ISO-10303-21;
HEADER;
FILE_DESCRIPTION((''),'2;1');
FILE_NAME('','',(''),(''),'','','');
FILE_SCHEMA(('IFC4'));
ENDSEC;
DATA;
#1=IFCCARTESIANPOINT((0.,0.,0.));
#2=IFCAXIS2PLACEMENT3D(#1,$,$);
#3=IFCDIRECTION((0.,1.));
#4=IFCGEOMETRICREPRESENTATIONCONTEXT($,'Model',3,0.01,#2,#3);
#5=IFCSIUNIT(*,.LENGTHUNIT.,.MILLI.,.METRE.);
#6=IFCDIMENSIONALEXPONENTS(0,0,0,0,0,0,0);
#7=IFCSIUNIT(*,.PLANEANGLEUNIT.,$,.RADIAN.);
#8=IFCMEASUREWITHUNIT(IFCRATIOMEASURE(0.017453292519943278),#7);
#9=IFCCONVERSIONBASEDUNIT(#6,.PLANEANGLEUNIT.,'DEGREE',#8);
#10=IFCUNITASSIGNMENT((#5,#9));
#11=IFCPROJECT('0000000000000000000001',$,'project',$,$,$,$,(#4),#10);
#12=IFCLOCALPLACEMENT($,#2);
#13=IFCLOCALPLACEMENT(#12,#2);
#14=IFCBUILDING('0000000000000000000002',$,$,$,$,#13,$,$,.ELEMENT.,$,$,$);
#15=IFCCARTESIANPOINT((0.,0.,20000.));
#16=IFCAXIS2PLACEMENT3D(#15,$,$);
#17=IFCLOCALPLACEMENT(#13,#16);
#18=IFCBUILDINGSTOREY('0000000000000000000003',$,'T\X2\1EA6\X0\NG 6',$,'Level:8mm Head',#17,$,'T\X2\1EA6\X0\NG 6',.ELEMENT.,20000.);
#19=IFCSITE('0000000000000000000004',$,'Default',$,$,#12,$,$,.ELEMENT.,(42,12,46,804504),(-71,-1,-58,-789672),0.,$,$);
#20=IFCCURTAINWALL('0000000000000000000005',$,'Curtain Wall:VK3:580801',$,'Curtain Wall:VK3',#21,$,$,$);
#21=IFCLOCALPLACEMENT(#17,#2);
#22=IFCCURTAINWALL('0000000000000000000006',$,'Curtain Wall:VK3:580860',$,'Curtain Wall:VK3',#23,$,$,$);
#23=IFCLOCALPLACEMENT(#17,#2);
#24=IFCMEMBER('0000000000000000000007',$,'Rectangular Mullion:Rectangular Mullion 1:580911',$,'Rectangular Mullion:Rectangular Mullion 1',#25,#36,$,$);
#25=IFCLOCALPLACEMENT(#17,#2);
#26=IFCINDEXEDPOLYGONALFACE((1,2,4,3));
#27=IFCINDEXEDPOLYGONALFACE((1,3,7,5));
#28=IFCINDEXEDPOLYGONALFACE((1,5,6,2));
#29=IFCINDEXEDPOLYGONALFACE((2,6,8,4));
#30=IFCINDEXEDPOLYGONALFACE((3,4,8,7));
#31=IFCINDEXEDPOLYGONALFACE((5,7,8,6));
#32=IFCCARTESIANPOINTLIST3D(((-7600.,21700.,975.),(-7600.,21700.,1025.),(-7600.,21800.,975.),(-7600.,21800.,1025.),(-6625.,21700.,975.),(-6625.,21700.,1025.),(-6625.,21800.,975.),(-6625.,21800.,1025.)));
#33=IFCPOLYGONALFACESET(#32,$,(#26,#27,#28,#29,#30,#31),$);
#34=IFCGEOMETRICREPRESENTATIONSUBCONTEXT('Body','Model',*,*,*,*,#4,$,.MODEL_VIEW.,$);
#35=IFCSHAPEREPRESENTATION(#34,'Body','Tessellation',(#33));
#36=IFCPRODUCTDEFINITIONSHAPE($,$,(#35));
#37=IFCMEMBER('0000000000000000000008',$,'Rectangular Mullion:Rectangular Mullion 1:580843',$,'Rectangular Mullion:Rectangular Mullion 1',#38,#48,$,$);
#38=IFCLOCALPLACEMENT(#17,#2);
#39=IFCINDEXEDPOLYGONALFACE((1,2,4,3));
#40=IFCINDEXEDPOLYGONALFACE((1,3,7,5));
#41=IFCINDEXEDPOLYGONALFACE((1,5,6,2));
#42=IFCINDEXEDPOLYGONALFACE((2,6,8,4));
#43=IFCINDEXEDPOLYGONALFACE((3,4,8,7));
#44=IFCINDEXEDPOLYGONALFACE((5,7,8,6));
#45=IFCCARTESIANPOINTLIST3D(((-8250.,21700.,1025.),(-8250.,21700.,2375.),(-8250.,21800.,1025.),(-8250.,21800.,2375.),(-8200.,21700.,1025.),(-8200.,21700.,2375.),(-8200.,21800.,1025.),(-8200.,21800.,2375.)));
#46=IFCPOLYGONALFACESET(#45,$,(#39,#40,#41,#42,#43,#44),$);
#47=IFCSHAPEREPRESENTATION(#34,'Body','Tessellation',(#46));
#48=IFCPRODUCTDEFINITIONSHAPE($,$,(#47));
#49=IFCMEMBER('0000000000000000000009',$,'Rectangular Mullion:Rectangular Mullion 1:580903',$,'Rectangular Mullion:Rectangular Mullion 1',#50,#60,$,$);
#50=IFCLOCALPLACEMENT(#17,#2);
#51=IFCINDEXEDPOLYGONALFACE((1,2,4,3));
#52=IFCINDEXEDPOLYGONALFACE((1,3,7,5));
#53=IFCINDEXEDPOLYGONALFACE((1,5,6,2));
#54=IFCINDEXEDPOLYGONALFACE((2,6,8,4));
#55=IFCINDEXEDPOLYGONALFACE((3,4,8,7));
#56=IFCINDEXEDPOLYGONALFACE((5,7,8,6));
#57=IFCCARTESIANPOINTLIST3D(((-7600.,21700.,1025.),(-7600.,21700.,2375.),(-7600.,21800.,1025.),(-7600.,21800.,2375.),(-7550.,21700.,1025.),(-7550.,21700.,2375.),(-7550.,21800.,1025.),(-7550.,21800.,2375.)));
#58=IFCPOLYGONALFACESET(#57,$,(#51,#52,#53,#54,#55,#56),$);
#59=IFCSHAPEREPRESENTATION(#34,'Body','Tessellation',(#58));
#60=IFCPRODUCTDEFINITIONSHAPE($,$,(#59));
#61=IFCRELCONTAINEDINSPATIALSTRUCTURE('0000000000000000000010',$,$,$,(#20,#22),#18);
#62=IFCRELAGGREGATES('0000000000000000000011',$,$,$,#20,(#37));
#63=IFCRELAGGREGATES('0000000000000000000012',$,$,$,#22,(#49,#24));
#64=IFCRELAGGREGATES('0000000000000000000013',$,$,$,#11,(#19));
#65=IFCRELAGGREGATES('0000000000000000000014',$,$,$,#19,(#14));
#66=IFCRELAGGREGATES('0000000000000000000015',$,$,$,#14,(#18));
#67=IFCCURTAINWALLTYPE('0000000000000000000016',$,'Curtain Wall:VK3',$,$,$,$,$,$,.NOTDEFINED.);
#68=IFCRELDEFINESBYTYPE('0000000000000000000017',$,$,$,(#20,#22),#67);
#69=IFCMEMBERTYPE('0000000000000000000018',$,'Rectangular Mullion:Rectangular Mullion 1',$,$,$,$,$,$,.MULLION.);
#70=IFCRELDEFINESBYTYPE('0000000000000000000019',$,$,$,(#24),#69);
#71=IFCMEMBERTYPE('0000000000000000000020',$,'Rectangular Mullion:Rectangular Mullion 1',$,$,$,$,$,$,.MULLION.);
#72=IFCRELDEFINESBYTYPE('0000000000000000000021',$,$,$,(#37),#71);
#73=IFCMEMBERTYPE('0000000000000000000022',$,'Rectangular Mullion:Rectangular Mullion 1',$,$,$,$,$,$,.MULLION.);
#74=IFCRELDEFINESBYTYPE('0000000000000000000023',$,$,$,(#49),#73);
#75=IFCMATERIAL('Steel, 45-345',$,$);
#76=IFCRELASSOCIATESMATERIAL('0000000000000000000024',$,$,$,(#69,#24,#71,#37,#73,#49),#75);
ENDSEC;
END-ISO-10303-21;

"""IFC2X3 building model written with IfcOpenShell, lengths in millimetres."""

from ifc_helpers import new_model, entity, si_unit, converted_unit, direction, frame, origin, origin_2d_with_axis, place, context, subcontext, project, spatial, rectangle, extrude, source, transform, mapped, material, type_object, type_shapes, element, aggregate, save


model = new_model("IFC2X3")

# Units and contexts
model_context = context("Model", 3, precision=0.01, world=origin(), true_north=direction((0.0, 1.0)))
body_context = subcontext(model_context, "Body", "Model", "MODEL_VIEW")
ifc_project = project(units=[si_unit("LENGTHUNIT", "METRE", prefix="MILLI"), converted_unit("PLANEANGLEUNIT", "DEGREE", entity("IfcRatioMeasure", 0.017453292519943278), si_unit("PLANEANGLEUNIT", "RADIAN"), dimensions=[0, 0, 0, 0, 0, 0, 0])], contexts=[model_context])

# Site, building, storey
site_placement = place(None, origin())
site = spatial("IfcSite", under=ifc_project, at=site_placement, Name="Default", CompositionType="ELEMENT", RefLatitude=(42, 12, 46, 804504), RefLongitude=(-71, -1, -58, -789672), RefElevation=0.0)
building_placement = place(site_placement, origin())
building = spatial("IfcBuilding", under=site, at=building_placement, CompositionType="ELEMENT")
storey_placement = place(building_placement, frame((0.0, 0.0, 20000.0)))
storey = spatial("IfcBuildingStorey", under=building, at=storey_placement, Name="TẦNG 6", ObjectType="Level:8mm Head", LongName="TẦNG 6", CompositionType="ELEMENT", Elevation=20000.0)

# Curtain walls
curtain_wall_type_1 = type_object("IfcCurtainWallType", Name="Curtain Wall:VK3", PredefinedType="NOTDEFINED")
curtain_wall_1_placement = place(storey_placement, frame((0.0, 0.0, -20000.0)))
curtain_wall_1 = element("IfcCurtainWall", 1, at=curtain_wall_1_placement, inside=storey, type_object=curtain_wall_type_1, Name="Curtain Wall:VK3:580801", ObjectType="Curtain Wall:VK3")
ifc_material_1 = material(Name="Steel, 45-345")
curtain_wall_2_placement = place(storey_placement, frame((0.0, 0.0, -20000.0)))
curtain_wall_2 = element("IfcCurtainWall", 2, at=curtain_wall_2_placement, inside=storey, type_object=curtain_wall_type_1, Name="Curtain Wall:VK3:580860", ObjectType="Curtain Wall:VK3")

# Members
member_type_1 = type_object("IfcMemberType", Name="Rectangular Mullion:Rectangular Mullion 1", PredefinedType="MULLION", material=ifc_material_1)
shared_shape_1 = source(origin(), body_context, "Body", "SweptSolid", [
    extrude(rectangle(XDim=100.0, YDim=50.0, at=origin_2d_with_axis()), frame((0.0, -50.0, -975.0), z_axis=(0.0, 0.0, 1.0), x_axis=(0.0, -1.0, 0.0)), (0.0, 0.0, 1.0), 975.0),
])
type_shapes(member_type_1, [shared_shape_1])
member_1_placement = place(curtain_wall_2_placement, frame((-6625.0, 21700.0, 21000.0), z_axis=(1.0, 0.0, 0.0), x_axis=(0.0, 0.0, 1.0)))
member_1 = element("IfcMember", 3, at=member_1_placement, type_object=member_type_1, material=ifc_material_1, Name="Rectangular Mullion:Rectangular Mullion 1:580911", ObjectType="Rectangular Mullion:Rectangular Mullion 1", context=body_context, shape_type="MappedRepresentation", body=[
    mapped(shared_shape_1, transform((0.0, 0.0, 0.0), scale=1.0)),
])
member_type_2 = type_object("IfcMemberType", Name="Rectangular Mullion:Rectangular Mullion 1", PredefinedType="MULLION", material=ifc_material_1)
shared_shape_2 = source(origin(), body_context, "Body", "SweptSolid", [
    extrude(rectangle(XDim=100.0, YDim=50.0, at=origin_2d_with_axis()), frame((-25.0, -50.0, -1350.0), z_axis=(0.0, 0.0, 1.0), x_axis=(0.0, -1.0, 0.0)), (0.0, 0.0, 1.0), 1350.0),
])
type_shapes(member_type_2, [shared_shape_2])
member_2_placement = place(curtain_wall_1_placement, frame((-8200.0, 21700.0, 21025.0), z_axis=(0.0, 0.0, -1.0), x_axis=(1.0, 0.0, 0.0)))
member_2 = element("IfcMember", 4, at=member_2_placement, type_object=member_type_2, material=ifc_material_1, Name="Rectangular Mullion:Rectangular Mullion 1:580843", ObjectType="Rectangular Mullion:Rectangular Mullion 1", context=body_context, shape_type="MappedRepresentation", body=[
    mapped(shared_shape_2, transform((0.0, 0.0, 0.0), scale=1.0)),
])
member_type_3 = type_object("IfcMemberType", Name="Rectangular Mullion:Rectangular Mullion 1", PredefinedType="MULLION", material=ifc_material_1)
shared_shape_3 = source(origin(), body_context, "Body", "SweptSolid", [
    extrude(rectangle(XDim=100.0, YDim=50.0, at=origin_2d_with_axis()), frame((-25.0, -50.0, -1350.0), z_axis=(0.0, 0.0, 1.0), x_axis=(0.0, -1.0, 0.0)), (0.0, 0.0, 1.0), 1350.0),
])
type_shapes(member_type_3, [shared_shape_3])
member_3_placement = place(curtain_wall_2_placement, frame((-7600.0, 21700.0, 22375.0), z_axis=(0.0, 0.0, 1.0), x_axis=(-1.0, 0.0, 0.0)))
member_3 = element("IfcMember", 5, at=member_3_placement, type_object=member_type_3, material=ifc_material_1, Name="Rectangular Mullion:Rectangular Mullion 1:580903", ObjectType="Rectangular Mullion:Rectangular Mullion 1", context=body_context, shape_type="MappedRepresentation", body=[
    mapped(shared_shape_3, transform((0.0, 0.0, 0.0), scale=1.0)),
])

aggregate(curtain_wall_1, [member_2])
aggregate(curtain_wall_2, [member_3, member_1])

save(model, "model.ifc")
